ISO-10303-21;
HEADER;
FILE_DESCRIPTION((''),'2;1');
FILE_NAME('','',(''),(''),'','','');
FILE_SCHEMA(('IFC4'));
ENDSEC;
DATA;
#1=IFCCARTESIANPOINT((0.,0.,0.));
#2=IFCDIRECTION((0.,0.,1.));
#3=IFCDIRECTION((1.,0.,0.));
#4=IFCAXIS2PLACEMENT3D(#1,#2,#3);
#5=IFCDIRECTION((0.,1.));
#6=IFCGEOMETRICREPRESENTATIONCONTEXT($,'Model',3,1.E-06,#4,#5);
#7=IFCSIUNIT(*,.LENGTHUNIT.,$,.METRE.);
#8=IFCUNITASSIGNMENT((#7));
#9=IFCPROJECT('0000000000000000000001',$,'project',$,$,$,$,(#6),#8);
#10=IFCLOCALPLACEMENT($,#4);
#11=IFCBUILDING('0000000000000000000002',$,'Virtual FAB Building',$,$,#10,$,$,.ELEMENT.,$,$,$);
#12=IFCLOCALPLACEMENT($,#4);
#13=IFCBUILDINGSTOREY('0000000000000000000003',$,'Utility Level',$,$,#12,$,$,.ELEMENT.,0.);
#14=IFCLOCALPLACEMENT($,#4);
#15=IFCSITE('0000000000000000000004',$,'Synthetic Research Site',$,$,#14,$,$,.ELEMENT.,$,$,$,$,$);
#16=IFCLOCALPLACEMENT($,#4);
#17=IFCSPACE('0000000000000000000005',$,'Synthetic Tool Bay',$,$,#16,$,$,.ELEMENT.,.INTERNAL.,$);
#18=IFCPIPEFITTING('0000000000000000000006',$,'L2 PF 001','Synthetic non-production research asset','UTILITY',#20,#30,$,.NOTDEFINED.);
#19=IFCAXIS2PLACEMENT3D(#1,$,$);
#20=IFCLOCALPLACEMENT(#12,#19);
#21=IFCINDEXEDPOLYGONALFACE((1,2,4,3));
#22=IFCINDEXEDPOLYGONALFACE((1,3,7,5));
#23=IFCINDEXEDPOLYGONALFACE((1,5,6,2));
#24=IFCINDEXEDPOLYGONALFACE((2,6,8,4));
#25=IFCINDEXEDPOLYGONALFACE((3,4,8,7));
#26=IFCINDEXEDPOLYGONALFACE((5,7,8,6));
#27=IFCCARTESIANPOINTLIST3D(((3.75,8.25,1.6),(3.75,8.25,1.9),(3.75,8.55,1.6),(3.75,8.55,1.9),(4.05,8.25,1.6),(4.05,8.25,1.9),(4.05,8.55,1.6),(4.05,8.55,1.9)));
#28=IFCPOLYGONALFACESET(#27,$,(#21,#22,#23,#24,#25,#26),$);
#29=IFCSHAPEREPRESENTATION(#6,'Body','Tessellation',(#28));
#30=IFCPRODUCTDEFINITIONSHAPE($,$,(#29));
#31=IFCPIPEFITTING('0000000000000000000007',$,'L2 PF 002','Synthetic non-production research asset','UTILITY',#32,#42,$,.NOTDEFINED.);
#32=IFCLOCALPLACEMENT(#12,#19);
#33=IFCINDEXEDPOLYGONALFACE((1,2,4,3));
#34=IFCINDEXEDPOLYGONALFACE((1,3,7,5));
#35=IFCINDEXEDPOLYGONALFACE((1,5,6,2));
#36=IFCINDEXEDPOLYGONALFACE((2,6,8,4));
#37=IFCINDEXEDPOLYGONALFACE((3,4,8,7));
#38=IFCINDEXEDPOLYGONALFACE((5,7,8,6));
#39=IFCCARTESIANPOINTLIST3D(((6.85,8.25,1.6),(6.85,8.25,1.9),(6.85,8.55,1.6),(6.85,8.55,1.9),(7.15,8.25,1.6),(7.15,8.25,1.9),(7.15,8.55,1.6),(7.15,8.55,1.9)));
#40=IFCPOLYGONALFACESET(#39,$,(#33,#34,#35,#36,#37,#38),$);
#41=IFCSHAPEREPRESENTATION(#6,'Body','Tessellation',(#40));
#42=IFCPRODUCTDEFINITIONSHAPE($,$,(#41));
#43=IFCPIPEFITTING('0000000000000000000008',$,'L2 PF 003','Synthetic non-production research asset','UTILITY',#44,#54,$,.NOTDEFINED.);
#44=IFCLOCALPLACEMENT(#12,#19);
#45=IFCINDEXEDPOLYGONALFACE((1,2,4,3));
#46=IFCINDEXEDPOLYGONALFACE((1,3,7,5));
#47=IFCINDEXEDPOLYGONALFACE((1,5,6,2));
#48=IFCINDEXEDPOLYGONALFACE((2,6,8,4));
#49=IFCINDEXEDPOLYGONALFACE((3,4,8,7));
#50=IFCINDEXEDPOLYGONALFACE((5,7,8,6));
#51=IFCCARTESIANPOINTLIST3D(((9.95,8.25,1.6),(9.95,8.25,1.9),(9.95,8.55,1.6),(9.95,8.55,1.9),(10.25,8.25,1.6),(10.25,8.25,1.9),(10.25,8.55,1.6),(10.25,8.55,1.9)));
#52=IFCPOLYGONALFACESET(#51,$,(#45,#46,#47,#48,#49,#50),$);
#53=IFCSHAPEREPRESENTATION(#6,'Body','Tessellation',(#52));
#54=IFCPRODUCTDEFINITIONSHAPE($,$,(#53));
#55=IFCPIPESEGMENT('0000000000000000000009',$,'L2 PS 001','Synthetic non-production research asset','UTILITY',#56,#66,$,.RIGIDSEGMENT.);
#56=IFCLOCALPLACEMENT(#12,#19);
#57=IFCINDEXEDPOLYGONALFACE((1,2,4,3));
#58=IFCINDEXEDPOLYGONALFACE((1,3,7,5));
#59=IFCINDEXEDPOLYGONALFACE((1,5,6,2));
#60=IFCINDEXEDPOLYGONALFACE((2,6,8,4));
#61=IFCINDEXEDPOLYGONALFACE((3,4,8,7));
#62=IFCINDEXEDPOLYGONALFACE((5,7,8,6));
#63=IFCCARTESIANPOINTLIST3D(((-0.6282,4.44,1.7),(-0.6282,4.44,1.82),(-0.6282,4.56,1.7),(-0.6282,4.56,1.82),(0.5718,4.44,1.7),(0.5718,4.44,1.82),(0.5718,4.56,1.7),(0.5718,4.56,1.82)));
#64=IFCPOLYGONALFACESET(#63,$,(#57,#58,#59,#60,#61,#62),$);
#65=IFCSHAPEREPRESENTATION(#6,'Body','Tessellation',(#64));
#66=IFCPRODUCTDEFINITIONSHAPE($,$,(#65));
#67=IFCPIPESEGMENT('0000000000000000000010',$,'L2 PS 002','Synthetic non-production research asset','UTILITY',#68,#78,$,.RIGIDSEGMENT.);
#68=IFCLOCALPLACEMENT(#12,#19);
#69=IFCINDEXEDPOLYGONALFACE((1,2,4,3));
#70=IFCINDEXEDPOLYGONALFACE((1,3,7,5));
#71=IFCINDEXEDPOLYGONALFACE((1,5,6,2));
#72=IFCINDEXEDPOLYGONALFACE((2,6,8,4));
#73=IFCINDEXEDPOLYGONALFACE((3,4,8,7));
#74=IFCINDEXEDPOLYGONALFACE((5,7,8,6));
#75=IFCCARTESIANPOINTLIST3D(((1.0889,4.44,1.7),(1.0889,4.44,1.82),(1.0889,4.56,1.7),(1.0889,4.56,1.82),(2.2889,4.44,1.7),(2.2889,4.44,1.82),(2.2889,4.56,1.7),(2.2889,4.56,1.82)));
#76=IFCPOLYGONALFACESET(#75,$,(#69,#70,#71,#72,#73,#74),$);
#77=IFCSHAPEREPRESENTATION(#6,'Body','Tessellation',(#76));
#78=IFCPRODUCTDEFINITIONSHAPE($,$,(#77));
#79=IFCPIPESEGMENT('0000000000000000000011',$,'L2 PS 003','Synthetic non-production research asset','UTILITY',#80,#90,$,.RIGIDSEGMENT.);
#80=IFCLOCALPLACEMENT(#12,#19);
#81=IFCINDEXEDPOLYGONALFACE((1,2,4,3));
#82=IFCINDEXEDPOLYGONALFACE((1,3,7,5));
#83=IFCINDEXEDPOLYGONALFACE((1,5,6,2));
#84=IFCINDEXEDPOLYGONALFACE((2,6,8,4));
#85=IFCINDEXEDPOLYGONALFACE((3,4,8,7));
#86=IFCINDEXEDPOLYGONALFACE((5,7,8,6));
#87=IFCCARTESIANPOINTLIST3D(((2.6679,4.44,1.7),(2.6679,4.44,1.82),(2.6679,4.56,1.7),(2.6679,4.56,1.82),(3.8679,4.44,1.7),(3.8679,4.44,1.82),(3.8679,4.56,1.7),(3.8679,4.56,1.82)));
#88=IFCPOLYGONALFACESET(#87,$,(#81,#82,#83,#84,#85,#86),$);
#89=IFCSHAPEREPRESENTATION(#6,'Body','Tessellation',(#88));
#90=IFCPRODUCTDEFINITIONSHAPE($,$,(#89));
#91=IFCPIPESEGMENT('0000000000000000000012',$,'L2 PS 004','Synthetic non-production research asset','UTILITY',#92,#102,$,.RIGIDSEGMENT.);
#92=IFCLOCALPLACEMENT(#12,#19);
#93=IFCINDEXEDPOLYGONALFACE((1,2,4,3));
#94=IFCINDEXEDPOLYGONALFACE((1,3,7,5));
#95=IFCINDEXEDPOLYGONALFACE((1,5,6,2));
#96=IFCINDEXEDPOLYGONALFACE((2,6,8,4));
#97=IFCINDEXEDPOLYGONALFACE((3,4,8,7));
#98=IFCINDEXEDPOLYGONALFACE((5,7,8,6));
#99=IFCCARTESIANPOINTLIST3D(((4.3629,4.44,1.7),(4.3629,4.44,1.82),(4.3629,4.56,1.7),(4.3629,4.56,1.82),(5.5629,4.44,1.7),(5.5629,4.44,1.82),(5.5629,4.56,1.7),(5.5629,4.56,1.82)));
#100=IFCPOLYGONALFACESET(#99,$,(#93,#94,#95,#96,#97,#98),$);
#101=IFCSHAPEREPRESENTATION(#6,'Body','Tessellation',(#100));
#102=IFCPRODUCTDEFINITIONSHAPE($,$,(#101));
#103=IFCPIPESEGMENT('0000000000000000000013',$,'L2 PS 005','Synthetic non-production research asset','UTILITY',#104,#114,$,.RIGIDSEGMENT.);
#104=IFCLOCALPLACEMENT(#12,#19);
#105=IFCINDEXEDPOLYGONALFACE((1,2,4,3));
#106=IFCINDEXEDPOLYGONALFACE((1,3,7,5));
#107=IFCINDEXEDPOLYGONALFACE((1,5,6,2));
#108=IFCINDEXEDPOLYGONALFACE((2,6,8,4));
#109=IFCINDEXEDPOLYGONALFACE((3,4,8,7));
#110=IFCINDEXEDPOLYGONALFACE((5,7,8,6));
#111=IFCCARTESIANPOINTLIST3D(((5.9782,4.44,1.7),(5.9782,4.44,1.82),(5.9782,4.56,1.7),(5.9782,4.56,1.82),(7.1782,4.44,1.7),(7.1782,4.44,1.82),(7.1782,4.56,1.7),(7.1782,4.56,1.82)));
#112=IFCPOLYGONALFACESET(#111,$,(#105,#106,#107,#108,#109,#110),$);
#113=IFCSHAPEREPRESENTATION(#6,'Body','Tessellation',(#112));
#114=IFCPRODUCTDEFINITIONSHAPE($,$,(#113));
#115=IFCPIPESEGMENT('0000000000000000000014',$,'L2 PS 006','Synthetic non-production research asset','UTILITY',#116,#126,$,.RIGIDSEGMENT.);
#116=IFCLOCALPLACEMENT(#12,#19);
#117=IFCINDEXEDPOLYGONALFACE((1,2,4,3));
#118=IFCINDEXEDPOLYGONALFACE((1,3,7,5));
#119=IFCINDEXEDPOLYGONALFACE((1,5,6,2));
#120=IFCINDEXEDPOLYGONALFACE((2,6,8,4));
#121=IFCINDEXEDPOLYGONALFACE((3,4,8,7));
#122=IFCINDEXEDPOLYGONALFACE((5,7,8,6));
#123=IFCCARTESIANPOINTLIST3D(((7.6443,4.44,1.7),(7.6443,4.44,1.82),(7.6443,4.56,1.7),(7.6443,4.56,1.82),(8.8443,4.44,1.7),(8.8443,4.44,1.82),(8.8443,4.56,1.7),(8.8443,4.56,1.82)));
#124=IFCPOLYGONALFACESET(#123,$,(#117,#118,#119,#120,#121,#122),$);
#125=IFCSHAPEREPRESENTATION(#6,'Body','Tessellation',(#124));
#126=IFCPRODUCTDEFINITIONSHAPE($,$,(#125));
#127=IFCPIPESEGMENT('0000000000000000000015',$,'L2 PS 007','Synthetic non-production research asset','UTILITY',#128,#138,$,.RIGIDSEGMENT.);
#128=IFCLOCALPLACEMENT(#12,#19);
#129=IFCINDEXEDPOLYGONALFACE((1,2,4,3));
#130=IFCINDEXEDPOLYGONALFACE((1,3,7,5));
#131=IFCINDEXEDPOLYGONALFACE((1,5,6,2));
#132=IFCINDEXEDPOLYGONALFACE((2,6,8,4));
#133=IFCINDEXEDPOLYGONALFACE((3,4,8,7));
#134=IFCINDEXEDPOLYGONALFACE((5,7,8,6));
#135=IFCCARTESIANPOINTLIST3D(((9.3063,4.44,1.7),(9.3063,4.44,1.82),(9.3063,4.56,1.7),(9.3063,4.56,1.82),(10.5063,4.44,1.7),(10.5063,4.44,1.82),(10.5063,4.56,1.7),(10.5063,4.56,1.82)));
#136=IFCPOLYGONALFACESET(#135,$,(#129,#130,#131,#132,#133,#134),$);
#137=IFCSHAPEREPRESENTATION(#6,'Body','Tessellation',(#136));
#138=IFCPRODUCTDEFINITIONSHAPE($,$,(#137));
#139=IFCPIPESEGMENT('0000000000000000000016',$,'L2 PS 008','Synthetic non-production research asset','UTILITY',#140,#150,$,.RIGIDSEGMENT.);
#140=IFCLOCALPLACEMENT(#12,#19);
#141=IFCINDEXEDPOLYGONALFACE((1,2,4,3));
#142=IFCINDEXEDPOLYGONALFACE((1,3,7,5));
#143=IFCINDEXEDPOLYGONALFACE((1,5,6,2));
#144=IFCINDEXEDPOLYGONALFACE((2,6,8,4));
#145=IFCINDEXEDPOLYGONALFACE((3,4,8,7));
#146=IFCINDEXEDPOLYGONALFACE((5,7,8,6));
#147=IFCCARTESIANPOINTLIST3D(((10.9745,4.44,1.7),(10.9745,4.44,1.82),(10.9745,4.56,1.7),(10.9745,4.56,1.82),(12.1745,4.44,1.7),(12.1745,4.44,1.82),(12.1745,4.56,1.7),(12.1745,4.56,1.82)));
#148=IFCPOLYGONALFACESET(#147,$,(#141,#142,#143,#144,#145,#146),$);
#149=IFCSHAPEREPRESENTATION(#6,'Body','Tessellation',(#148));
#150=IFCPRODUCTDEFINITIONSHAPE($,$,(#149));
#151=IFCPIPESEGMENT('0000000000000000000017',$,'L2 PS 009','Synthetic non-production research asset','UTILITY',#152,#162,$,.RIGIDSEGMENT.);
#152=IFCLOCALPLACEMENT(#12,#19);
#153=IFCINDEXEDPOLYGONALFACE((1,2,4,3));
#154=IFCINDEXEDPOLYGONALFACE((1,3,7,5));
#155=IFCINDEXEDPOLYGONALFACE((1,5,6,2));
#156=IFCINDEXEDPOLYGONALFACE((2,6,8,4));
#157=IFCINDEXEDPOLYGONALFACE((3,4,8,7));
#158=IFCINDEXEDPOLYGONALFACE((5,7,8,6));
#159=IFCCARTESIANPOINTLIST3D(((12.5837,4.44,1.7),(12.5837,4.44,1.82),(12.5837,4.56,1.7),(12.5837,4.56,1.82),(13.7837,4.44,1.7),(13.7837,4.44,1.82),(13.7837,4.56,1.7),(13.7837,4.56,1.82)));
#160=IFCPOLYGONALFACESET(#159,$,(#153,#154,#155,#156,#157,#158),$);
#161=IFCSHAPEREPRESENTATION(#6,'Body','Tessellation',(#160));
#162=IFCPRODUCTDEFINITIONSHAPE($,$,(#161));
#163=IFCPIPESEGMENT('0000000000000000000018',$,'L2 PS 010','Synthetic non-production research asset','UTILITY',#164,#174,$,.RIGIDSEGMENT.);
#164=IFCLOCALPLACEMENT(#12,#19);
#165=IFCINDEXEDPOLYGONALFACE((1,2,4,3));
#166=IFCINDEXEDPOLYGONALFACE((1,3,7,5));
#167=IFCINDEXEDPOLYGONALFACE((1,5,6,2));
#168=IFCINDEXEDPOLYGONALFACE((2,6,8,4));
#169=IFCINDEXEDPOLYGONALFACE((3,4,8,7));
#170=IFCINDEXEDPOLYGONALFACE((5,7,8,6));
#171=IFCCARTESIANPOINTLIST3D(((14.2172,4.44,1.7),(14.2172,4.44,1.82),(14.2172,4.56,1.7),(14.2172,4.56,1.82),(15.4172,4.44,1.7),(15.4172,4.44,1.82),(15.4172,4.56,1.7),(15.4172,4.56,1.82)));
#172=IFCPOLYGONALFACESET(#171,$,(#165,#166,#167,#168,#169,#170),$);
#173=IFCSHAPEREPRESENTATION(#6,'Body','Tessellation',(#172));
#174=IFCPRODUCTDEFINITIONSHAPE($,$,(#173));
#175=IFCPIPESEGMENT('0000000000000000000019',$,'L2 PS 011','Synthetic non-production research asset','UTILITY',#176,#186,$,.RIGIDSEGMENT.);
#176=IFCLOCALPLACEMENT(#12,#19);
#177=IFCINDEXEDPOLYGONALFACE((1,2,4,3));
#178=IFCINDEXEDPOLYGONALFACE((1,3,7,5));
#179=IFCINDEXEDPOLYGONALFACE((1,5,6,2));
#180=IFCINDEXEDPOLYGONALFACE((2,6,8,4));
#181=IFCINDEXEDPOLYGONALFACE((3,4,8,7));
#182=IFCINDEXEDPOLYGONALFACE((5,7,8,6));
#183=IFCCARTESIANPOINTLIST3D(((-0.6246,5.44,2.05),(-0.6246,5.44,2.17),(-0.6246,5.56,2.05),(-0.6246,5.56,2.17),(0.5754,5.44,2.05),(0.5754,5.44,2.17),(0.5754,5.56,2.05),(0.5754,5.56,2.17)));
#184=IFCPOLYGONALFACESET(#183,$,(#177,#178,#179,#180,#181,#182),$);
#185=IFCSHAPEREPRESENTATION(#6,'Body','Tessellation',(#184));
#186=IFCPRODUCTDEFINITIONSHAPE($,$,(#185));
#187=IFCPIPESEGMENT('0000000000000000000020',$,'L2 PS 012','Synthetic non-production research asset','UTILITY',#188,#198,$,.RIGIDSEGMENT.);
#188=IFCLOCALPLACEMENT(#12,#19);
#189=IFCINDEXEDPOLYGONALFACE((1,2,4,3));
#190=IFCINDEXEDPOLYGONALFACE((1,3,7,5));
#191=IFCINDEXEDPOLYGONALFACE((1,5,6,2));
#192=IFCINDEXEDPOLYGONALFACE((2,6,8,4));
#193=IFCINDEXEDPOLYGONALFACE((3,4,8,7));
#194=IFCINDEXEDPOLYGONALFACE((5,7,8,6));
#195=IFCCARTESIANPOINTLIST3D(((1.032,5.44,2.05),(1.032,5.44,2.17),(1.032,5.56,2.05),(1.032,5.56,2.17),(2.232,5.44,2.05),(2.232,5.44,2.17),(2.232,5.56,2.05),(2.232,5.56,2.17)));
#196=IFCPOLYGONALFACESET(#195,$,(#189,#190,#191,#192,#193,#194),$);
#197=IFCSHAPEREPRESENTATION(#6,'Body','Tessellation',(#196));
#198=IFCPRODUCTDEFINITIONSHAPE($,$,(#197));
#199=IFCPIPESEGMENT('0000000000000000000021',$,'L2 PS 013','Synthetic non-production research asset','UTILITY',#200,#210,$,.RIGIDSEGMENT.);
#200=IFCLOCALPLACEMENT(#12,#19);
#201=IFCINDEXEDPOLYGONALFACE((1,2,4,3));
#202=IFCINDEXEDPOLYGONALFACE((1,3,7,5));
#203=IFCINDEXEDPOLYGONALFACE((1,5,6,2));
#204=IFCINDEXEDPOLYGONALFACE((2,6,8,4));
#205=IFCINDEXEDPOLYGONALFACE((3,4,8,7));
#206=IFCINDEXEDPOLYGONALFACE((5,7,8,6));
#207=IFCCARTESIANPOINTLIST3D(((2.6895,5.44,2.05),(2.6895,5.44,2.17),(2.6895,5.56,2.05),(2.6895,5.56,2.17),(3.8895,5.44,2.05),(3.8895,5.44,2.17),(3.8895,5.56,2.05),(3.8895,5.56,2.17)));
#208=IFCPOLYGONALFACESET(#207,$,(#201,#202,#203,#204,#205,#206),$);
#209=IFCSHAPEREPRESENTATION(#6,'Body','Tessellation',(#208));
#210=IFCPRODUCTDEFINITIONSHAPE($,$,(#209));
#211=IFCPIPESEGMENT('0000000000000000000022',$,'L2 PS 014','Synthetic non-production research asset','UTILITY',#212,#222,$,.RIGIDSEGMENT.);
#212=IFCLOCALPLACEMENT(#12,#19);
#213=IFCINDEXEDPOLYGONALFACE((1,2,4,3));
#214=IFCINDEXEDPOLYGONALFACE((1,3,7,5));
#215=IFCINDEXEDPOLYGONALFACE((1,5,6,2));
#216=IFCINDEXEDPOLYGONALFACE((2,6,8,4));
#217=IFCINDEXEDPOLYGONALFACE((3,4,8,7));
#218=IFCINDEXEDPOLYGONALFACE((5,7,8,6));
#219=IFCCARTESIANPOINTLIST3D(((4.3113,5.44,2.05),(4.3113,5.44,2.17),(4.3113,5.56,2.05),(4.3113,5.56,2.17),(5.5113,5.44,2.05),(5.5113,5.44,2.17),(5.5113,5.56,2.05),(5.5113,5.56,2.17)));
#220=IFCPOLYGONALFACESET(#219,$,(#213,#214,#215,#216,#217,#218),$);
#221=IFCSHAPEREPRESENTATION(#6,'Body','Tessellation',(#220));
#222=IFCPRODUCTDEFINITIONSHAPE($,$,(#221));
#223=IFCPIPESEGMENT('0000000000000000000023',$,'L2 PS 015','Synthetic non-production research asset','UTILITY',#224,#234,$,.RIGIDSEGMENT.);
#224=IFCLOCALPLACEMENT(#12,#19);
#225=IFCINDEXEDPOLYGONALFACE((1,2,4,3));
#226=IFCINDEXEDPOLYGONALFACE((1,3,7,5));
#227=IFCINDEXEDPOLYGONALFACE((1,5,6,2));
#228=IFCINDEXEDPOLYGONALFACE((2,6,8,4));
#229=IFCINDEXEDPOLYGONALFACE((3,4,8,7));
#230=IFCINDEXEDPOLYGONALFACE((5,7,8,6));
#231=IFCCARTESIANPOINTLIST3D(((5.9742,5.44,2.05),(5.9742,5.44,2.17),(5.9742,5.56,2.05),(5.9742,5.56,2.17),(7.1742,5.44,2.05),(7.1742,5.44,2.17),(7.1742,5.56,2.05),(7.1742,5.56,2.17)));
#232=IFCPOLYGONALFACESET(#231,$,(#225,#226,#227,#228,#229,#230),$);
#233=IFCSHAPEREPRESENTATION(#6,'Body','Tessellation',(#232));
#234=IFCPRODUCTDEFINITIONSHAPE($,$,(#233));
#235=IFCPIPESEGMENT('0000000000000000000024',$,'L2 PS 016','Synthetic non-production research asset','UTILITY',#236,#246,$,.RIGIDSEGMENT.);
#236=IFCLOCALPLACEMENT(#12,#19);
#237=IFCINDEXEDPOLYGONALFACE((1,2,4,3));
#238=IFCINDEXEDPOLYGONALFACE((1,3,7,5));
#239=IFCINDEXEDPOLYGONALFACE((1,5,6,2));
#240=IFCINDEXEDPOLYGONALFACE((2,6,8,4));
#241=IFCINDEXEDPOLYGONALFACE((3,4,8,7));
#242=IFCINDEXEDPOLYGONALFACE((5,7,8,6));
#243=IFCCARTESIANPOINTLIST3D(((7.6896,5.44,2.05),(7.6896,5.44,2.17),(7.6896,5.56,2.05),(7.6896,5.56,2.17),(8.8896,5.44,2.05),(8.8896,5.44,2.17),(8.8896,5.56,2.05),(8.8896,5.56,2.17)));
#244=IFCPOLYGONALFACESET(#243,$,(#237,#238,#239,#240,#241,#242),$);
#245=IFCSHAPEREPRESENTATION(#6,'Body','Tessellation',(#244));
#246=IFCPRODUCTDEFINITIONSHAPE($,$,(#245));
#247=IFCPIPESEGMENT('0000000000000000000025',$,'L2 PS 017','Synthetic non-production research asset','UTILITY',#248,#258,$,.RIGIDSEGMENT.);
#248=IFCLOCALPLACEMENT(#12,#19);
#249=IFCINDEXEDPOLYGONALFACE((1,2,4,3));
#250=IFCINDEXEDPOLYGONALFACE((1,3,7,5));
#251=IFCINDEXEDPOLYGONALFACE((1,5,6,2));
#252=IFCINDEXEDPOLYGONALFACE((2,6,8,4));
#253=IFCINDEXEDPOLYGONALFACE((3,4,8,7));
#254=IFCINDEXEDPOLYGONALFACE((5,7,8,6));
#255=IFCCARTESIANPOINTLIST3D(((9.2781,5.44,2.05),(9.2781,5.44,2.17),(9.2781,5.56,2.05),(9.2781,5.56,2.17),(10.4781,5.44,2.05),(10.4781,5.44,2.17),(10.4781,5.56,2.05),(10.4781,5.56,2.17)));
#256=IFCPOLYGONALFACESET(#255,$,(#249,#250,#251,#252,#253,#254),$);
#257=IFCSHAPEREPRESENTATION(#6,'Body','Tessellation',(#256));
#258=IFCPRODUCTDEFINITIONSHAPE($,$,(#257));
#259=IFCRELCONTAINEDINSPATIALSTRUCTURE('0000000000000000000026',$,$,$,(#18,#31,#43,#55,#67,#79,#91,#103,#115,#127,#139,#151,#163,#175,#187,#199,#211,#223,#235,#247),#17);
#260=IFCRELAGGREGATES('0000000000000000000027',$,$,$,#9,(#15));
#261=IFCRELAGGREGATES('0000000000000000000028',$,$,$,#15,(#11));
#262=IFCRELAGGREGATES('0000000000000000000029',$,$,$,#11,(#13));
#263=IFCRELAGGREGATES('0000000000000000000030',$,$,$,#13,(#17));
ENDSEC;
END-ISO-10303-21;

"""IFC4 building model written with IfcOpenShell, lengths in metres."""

from ifc_helpers import new_model, si_unit, direction, frame, origin_with_axes, origin_2d_with_axis, place, context, project, spatial, rectangle, extrude, element, save


model = new_model("IFC4")

# Units and contexts
model_context = context("Model", 3, precision=1e-06, world=origin_with_axes(), true_north=direction((0.0, 1.0)))
ifc_project = project(units=[si_unit("LENGTHUNIT", "METRE")], contexts=[model_context])

# Site, building, storey, space
site_placement = place(None, origin_with_axes())
site = spatial("IfcSite", under=ifc_project, at=site_placement, Name="Synthetic Research Site", CompositionType="ELEMENT")
building_placement = place(None, origin_with_axes())
building = spatial("IfcBuilding", under=site, at=building_placement, Name="Virtual FAB Building", CompositionType="ELEMENT")
storey_placement = place(None, origin_with_axes())
storey = spatial("IfcBuildingStorey", under=building, at=storey_placement, Name="Utility Level", CompositionType="ELEMENT", Elevation=0.0)
space_placement = place(None, origin_with_axes())
space = spatial("IfcSpace", under=storey, at=space_placement, Name="Synthetic Tool Bay", CompositionType="ELEMENT", PredefinedType="INTERNAL")

# Pipe fittings
for number, where, z_axis, x_axis, name in (
    (1, (3.9, 8.4, 1.6), (0.0, 0.0, 1.0), (1.0, 0.0, 0.0), "L2 PF 001"),
    (2, (7.0, 8.4, 1.6), (0.0, 0.0, 1.0), (1.0, 0.0, 0.0), "L2 PF 002"),
    (3, (10.1, 8.4, 1.6), (0.0, 0.0, 1.0), (1.0, 0.0, 0.0), "L2 PF 003"),
):
    element("IfcPipeFitting", number, at=place(None, frame(where, z_axis=z_axis, x_axis=x_axis)), inside=space, Name=name, Description="Synthetic non-production research asset", ObjectType="UTILITY", PredefinedType="NOTDEFINED", context=model_context, shape_type="SweptSolid", body=[
        extrude(rectangle(XDim=0.3, YDim=0.3, at=origin_2d_with_axis()), origin_with_axes(), (0.0, 0.0, 1.0), 0.3),
    ])

# Pipe segments
for number, where, z_axis, x_axis, name in (
    (4, (-0.0282, 4.5, 1.7), (0.0, 0.0, 1.0), (1.0, 0.0, 0.0), "L2 PS 001"),
    (5, (1.6889, 4.5, 1.7), (0.0, 0.0, 1.0), (1.0, 0.0, 0.0), "L2 PS 002"),
    (6, (3.2679, 4.5, 1.7), (0.0, 0.0, 1.0), (1.0, 0.0, 0.0), "L2 PS 003"),
    (7, (4.9629, 4.5, 1.7), (0.0, 0.0, 1.0), (1.0, 0.0, 0.0), "L2 PS 004"),
    (8, (6.5782, 4.5, 1.7), (0.0, 0.0, 1.0), (1.0, 0.0, 0.0), "L2 PS 005"),
    (9, (8.2443, 4.5, 1.7), (0.0, 0.0, 1.0), (1.0, 0.0, 0.0), "L2 PS 006"),
    (10, (9.9063, 4.5, 1.7), (0.0, 0.0, 1.0), (1.0, 0.0, 0.0), "L2 PS 007"),
    (11, (11.5745, 4.5, 1.7), (0.0, 0.0, 1.0), (1.0, 0.0, 0.0), "L2 PS 008"),
    (12, (13.1837, 4.5, 1.7), (0.0, 0.0, 1.0), (1.0, 0.0, 0.0), "L2 PS 009"),
    (13, (14.8172, 4.5, 1.7), (0.0, 0.0, 1.0), (1.0, 0.0, 0.0), "L2 PS 010"),
    (14, (-0.0246, 5.5, 2.05), (0.0, 0.0, 1.0), (1.0, 0.0, 0.0), "L2 PS 011"),
    (15, (1.632, 5.5, 2.05), (0.0, 0.0, 1.0), (1.0, 0.0, 0.0), "L2 PS 012"),
    (16, (3.2895, 5.5, 2.05), (0.0, 0.0, 1.0), (1.0, 0.0, 0.0), "L2 PS 013"),
    (17, (4.9113, 5.5, 2.05), (0.0, 0.0, 1.0), (1.0, 0.0, 0.0), "L2 PS 014"),
    (18, (6.5742, 5.5, 2.05), (0.0, 0.0, 1.0), (1.0, 0.0, 0.0), "L2 PS 015"),
    (19, (8.2896, 5.5, 2.05), (0.0, 0.0, 1.0), (1.0, 0.0, 0.0), "L2 PS 016"),
    (20, (9.8781, 5.5, 2.05), (0.0, 0.0, 1.0), (1.0, 0.0, 0.0), "L2 PS 017"),
):
    element("IfcPipeSegment", number, at=place(None, frame(where, z_axis=z_axis, x_axis=x_axis)), inside=space, Name=name, Description="Synthetic non-production research asset", ObjectType="UTILITY", PredefinedType="RIGIDSEGMENT", context=model_context, shape_type="SweptSolid", body=[
        extrude(rectangle(XDim=1.2, YDim=0.12, at=origin_2d_with_axis()), origin_with_axes(), (0.0, 0.0, 1.0), 0.12),
    ])

save(model, "model.ifc")
